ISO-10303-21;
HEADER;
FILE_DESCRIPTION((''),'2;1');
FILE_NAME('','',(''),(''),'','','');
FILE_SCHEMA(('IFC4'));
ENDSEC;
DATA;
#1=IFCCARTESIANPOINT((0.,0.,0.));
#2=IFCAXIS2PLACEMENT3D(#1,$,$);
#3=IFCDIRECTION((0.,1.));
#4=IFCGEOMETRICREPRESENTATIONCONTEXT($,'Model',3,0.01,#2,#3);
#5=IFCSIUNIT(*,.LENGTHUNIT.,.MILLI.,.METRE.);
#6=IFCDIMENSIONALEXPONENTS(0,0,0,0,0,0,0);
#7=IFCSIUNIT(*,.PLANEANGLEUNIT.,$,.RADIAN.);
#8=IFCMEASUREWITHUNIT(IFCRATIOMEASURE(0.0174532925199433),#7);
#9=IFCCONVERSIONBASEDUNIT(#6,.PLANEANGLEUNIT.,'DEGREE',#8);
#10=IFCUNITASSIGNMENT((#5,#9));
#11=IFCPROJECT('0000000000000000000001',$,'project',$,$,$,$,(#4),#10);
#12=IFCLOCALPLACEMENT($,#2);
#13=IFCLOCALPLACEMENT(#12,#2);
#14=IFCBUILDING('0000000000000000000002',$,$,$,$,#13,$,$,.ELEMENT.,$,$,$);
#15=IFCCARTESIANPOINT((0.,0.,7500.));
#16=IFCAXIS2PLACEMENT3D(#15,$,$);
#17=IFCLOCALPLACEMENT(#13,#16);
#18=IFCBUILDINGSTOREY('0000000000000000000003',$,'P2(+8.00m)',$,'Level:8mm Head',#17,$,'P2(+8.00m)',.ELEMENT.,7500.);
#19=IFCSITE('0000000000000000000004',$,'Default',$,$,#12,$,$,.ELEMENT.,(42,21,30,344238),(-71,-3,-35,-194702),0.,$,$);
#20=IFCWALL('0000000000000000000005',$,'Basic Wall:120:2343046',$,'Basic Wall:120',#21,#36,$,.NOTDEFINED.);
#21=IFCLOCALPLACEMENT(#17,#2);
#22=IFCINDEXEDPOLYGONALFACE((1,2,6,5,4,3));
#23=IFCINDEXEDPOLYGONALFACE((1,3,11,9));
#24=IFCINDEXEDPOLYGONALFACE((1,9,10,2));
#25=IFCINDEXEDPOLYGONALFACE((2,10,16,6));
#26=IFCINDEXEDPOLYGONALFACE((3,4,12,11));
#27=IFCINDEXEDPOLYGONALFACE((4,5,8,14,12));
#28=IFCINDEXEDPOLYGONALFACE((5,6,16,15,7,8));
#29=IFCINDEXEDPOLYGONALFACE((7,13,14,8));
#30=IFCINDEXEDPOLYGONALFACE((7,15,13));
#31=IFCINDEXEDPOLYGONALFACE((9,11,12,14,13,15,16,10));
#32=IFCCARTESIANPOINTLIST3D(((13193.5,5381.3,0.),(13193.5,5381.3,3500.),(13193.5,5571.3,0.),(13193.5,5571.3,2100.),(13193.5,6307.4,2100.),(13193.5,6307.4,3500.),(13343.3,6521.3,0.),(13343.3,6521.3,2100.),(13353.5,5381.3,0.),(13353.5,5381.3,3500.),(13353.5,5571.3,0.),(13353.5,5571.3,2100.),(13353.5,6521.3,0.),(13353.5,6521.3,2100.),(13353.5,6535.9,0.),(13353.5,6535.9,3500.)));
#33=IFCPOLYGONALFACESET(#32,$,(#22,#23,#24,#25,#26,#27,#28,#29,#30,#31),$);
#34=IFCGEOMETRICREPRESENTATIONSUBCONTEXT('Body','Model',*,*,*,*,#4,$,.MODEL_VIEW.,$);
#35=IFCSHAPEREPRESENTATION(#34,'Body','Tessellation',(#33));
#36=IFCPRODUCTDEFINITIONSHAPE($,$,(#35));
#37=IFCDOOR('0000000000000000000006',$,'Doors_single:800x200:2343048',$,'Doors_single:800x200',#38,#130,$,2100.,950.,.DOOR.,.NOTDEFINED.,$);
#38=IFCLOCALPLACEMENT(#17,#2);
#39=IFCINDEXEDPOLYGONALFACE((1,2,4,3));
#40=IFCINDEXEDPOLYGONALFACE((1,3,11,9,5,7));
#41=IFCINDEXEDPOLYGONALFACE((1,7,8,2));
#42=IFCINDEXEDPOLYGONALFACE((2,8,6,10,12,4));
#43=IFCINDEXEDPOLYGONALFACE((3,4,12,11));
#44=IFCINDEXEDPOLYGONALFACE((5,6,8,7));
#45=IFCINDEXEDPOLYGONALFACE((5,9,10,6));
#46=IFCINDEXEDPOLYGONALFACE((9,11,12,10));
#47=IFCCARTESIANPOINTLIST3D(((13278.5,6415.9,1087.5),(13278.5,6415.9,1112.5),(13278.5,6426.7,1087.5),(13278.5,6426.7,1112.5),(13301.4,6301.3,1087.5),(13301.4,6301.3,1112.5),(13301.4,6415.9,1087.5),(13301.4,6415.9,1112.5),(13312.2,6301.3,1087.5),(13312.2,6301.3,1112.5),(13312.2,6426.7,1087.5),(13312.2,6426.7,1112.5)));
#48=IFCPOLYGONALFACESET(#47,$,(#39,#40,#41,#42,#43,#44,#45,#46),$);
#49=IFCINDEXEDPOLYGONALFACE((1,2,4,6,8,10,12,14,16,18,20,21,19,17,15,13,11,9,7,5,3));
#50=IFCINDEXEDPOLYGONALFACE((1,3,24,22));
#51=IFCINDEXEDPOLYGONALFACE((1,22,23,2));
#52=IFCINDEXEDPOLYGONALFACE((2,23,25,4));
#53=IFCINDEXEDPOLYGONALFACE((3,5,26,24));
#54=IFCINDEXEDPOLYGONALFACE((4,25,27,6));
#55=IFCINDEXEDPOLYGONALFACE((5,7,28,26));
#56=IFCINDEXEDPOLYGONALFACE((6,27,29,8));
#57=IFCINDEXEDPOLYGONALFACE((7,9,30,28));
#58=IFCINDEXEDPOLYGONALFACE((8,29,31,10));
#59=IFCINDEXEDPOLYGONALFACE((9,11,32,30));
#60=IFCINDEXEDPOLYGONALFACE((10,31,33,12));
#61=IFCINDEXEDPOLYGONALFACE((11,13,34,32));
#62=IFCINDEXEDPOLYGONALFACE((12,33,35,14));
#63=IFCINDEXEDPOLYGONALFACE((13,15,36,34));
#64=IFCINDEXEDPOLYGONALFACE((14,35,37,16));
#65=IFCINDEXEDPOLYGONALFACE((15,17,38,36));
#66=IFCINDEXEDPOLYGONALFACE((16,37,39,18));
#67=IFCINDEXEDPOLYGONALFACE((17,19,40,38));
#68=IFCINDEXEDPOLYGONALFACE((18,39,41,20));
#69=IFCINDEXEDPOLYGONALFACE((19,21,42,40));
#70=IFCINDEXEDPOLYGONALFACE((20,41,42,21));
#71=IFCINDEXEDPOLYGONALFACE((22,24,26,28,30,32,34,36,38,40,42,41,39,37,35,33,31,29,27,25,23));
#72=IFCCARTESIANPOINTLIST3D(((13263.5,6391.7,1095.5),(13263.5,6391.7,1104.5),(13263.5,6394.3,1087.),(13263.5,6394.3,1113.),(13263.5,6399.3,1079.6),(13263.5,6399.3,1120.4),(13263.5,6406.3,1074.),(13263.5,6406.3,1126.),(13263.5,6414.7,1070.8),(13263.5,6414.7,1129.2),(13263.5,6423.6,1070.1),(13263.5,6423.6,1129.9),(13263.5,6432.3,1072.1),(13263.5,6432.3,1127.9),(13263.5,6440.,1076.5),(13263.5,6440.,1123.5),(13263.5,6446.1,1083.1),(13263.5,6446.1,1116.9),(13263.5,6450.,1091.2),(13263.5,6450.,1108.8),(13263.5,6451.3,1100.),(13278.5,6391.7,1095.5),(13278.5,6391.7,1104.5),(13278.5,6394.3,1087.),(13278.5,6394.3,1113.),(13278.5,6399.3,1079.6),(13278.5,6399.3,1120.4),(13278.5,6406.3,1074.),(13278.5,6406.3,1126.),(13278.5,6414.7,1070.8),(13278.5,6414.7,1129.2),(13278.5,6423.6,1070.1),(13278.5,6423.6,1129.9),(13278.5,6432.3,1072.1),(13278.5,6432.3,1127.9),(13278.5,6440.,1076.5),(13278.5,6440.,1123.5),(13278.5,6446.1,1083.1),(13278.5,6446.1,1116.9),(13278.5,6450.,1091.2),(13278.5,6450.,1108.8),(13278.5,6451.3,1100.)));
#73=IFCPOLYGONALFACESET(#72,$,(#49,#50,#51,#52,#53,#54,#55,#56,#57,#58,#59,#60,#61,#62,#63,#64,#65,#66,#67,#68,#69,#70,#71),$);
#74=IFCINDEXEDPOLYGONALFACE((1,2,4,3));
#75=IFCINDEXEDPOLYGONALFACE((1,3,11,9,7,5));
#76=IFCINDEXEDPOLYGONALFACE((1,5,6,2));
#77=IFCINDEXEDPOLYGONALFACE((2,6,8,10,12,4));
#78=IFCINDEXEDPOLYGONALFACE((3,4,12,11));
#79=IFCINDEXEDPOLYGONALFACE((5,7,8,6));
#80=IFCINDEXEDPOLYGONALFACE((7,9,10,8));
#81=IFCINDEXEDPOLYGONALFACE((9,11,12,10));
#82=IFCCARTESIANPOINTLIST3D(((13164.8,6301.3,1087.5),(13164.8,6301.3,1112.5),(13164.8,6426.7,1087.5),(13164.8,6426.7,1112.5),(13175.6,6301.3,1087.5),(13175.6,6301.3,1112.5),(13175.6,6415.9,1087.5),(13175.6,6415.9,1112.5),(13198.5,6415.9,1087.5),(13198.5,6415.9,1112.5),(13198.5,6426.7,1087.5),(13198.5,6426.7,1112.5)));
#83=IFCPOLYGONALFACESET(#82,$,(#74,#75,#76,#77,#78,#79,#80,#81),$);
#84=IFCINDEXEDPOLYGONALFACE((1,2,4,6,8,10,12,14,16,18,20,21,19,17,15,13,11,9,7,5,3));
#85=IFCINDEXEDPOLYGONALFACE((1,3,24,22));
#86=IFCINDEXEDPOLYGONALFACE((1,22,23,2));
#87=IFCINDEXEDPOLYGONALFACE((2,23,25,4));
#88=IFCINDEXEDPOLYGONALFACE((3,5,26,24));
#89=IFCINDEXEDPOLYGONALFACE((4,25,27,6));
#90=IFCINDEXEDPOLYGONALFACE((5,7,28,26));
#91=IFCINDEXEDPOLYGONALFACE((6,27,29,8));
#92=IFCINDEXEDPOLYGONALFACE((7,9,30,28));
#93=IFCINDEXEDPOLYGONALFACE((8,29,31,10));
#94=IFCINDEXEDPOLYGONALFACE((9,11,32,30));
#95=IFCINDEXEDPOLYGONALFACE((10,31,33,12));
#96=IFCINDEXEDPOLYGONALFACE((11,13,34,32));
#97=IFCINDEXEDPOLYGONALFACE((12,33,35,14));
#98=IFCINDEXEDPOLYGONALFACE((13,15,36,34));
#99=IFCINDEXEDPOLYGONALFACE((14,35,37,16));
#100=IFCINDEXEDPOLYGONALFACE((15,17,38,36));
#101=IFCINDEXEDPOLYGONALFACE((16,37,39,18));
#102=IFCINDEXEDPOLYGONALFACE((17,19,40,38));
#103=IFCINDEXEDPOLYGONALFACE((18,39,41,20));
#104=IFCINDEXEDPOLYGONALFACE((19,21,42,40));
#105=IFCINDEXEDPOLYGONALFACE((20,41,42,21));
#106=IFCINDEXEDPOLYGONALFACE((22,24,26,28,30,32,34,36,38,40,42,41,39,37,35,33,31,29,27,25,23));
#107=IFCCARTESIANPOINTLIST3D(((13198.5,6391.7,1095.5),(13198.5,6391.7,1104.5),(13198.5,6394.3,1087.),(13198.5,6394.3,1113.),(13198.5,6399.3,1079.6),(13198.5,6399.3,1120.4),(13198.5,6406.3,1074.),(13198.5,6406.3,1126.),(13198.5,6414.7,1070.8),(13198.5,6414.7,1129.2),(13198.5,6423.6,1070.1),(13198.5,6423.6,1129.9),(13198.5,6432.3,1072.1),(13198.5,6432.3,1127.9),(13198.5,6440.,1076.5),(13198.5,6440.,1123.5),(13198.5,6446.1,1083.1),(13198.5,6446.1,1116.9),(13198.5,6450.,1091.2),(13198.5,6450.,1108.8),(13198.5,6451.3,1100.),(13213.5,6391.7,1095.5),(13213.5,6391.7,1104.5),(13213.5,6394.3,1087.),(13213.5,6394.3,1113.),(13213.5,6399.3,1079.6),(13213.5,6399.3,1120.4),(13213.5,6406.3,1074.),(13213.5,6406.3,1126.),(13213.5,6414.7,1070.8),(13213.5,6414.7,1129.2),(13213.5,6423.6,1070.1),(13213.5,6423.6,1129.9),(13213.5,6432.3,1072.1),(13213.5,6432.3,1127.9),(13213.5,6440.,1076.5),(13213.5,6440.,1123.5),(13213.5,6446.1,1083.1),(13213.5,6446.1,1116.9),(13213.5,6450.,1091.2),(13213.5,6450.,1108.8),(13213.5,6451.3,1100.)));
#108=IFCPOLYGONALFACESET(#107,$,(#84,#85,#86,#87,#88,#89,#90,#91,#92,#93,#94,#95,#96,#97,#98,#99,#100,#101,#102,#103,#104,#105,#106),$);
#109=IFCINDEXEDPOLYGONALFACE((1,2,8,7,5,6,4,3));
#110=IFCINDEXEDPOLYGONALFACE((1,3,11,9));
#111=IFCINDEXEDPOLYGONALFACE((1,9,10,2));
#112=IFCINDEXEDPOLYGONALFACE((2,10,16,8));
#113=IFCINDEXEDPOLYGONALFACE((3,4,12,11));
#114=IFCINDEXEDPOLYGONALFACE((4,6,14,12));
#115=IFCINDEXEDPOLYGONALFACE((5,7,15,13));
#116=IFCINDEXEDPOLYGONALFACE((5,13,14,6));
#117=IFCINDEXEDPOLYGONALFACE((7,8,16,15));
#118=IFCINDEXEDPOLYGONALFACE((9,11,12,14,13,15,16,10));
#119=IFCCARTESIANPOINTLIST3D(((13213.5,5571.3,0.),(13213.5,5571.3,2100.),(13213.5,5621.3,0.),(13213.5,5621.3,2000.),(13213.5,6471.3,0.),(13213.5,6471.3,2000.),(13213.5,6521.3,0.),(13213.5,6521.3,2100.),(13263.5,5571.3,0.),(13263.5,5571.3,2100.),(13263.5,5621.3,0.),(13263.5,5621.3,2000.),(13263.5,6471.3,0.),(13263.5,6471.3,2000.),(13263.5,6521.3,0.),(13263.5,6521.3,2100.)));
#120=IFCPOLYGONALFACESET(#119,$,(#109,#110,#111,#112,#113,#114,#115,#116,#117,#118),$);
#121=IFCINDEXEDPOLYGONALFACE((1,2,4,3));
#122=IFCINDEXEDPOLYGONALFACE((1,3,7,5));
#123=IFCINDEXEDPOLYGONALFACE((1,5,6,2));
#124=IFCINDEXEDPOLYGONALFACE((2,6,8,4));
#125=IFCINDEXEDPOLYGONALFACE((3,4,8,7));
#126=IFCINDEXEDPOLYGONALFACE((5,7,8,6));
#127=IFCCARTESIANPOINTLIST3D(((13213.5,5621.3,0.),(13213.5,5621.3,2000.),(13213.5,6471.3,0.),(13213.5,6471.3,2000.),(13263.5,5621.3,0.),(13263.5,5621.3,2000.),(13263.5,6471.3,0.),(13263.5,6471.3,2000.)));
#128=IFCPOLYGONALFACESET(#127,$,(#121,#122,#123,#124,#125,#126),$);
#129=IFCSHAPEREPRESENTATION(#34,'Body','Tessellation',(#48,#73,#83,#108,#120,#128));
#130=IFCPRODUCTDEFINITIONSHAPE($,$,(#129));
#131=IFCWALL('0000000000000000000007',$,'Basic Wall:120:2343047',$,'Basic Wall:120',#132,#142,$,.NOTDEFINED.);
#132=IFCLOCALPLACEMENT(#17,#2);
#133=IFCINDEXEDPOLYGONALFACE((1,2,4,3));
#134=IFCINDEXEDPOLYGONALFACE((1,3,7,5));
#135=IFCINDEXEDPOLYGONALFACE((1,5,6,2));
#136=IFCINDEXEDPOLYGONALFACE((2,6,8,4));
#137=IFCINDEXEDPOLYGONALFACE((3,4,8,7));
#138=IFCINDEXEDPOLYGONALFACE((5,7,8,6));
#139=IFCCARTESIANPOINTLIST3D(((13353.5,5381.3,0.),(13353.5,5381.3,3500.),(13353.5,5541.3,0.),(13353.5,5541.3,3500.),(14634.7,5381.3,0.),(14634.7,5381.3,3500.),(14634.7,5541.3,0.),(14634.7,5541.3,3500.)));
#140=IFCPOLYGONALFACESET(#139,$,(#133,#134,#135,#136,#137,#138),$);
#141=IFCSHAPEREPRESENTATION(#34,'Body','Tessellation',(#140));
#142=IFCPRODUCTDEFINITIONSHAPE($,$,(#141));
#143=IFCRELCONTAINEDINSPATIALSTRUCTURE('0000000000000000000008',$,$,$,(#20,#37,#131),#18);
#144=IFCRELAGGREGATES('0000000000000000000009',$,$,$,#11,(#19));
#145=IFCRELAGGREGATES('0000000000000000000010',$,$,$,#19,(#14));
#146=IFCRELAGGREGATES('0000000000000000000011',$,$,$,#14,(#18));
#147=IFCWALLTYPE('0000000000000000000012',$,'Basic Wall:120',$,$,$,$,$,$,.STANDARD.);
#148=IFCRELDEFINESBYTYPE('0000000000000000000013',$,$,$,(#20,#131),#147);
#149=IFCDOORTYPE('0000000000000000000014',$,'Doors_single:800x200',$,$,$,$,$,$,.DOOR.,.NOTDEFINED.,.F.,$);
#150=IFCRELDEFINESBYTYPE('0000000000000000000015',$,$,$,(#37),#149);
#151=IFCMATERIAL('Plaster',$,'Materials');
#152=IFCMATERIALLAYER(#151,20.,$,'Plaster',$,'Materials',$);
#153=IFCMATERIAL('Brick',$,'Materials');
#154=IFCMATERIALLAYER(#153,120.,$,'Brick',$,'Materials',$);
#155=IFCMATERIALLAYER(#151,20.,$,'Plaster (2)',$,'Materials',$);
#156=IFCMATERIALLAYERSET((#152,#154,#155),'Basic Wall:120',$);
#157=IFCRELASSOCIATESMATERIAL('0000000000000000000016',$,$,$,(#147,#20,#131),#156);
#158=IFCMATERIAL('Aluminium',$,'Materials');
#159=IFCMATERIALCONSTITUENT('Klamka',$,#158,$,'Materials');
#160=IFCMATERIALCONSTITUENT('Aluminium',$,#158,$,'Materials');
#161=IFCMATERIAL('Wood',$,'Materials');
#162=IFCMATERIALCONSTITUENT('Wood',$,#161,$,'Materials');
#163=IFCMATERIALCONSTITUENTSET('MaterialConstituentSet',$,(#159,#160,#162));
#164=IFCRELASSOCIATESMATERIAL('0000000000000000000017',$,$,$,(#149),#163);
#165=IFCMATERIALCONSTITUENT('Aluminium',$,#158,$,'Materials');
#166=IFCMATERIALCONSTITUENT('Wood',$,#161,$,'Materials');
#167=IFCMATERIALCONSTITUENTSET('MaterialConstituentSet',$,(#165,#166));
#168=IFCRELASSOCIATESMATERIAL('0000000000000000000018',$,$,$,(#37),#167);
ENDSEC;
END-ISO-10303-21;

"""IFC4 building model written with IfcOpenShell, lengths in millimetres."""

from ifc_helpers import new_model, entity, si_unit, converted_unit, direction, frame, frame_2d, origin, origin_2d_with_axis, place, context, subcontext, project, spatial, polyline, rectangle, circle, outline, extrude, source, transform, mapped, material, layer, layer_set, layer_usage, constituent, constituent_set, type_object, type_shapes, element, fill, save


model = new_model("IFC4")

# Units and contexts
model_context = context("Model", 3, precision=0.01, world=origin(), true_north=direction((0.0, 1.0)))
body_context = subcontext(model_context, "Body", "Model", "MODEL_VIEW")
ifc_project = project(units=[si_unit("LENGTHUNIT", "METRE", prefix="MILLI"), converted_unit("PLANEANGLEUNIT", "DEGREE", entity("IfcRatioMeasure", 0.0174532925199433), si_unit("PLANEANGLEUNIT", "RADIAN"), dimensions=[0, 0, 0, 0, 0, 0, 0])], contexts=[model_context])

# Site, building, storey
site_placement = place(None, origin())
site = spatial("IfcSite", under=ifc_project, at=site_placement, Name="Default", CompositionType="ELEMENT", RefLatitude=(42, 21, 30, 344238), RefLongitude=(-71, -3, -35, -194702), RefElevation=0.0)
building_placement = place(site_placement, origin())
building = spatial("IfcBuilding", under=site, at=building_placement, CompositionType="ELEMENT")
storey_placement = place(building_placement, frame((0.0, 0.0, 7500.0)))
storey = spatial("IfcBuildingStorey", under=building, at=storey_placement, Name="P2(+8.00m)", ObjectType="Level:8mm Head", LongName="P2(+8.00m)", CompositionType="ELEMENT", Elevation=7500.0)

# Shared definitions
ifc_material_1 = material(Name="Brick", Category="Materials")
ifc_material_2 = material(Name="Plaster", Category="Materials")

# Shared definitions
ifc_material_3 = material(Name="Aluminium", Category="Materials")
ifc_material_4 = material(Name="Wood", Category="Materials")

# Shared definitions
ifc_layer_1 = layer(ifc_material_2, 20.0, Name="Plaster", Category="Materials")
ifc_layer_2 = layer(ifc_material_1, 120.0, Name="Brick", Category="Materials")
ifc_layer_3 = layer(ifc_material_2, 20.0, Name="Plaster (2)", Category="Materials")
ifc_layer_set_1 = layer_set([ifc_layer_1, ifc_layer_2, ifc_layer_3], Name="Basic Wall:120")
wall_type_1 = type_object("IfcWallType", Name="Basic Wall:120", PredefinedType="STANDARD", material=ifc_layer_set_1)

# Wall, opening, door
ifc_layer_usage_1 = layer_usage(ifc_layer_set_1, "AXIS2", "POSITIVE", -80.0)
wall_1_placement = place(storey_placement, frame((13273.5, 6535.9, 0.0), z_axis=(0.0, 0.0, 1.0), x_axis=(0.0, -1.0, 0.0)))
wall_1 = element("IfcWall", 1, at=wall_1_placement, inside=storey, type_object=wall_type_1, material=ifc_layer_usage_1, Name="Basic Wall:120:2343046", ObjectType="Basic Wall:120", PredefinedType="NOTDEFINED", context=body_context, shape_type="SweptSolid", body=[
    extrude(outline(polyline([(228.5, -80.0), (1154.6, -80.0), (1154.6, 80.0), (994.6, 80.0), (0.0, 80.0), (228.5, -80.0)])), origin(), (0.0, 0.0, 1.0), 3500.0),
])
opening_1_placement = place(wall_1_placement, frame((964.6, 80.0, 0.0)))
opening_1 = element("IfcOpeningElement", 2, at=opening_1_placement, cuts=wall_1, PredefinedType="OPENING", context=body_context, shape_type="SweptSolid", body=[
    extrude(rectangle(XDim=2100.0, YDim=950.0, at=frame_2d((1050.0, 475.0), x_axis=(1.0, 0.0))), frame((0.0, 0.0, 0.0), z_axis=(0.0, -1.0, 0.0), x_axis=(0.0, 0.0, 1.0)), (0.0, 0.0, 1.0), 160.0),
])
ifc_constituent_1 = constituent(ifc_material_3, Name="Aluminium", Category="Materials")
ifc_constituent_2 = constituent(ifc_material_4, Name="Wood", Category="Materials")
ifc_constituent_set_1 = constituent_set(constituents=[ifc_constituent_1, ifc_constituent_2], Name="MaterialConstituentSet")
ifc_constituent_3 = constituent(ifc_material_3, Name="Klamka", Category="Materials")
ifc_constituent_4 = constituent(ifc_material_3, Name="Aluminium", Category="Materials")
ifc_constituent_5 = constituent(ifc_material_4, Name="Wood", Category="Materials")
ifc_constituent_set_2 = constituent_set(constituents=[ifc_constituent_3, ifc_constituent_4, ifc_constituent_5], Name="MaterialConstituentSet")
door_type_1 = type_object("IfcDoorType", Name="Doors_single:800x200", OperationType="NOTDEFINED", ParameterTakesPrecedence=False, PredefinedType="DOOR", material=ifc_constituent_set_2)
shared_shape_1 = source(origin(), body_context, "Body", "SweptSolid", [
    extrude(outline(polyline([(-45.4, -18.9), (-34.6, -18.9), (-34.6, 4.0), (80.0, 4.0), (80.0, 14.8), (-45.4, 14.8), (-45.4, -18.9)])), frame((810.0, 56.1, 1087.5), z_axis=(0.0, 0.0, 1.0), x_axis=(-1.0, 0.0, 0.0)), (0.0, 0.0, 1.0), 25.0),
    extrude(circle(Radius=30.0, at=origin_2d_with_axis()), frame((850.0, 75.0, 1100.0), z_axis=(0.0, 1.0, 0.0), x_axis=(1.0, 0.0, 0.0)), (0.0, 0.0, 1.0), 15.0),
    extrude(outline(polyline([(-18.9, -45.4), (14.8, -45.4), (14.8, 80.0), (4.0, 80.0), (4.0, -34.6), (-18.9, -34.6), (-18.9, -45.4)])), frame((810.0, 173.9, 1087.5), z_axis=(0.0, 0.0, 1.0), x_axis=(0.0, 1.0, 0.0)), (0.0, 0.0, 1.0), 25.0),
    extrude(circle(Radius=30.0, at=origin_2d_with_axis()), frame((850.0, 140.0, 1100.0), z_axis=(0.0, 1.0, 0.0), x_axis=(1.0, 0.0, 0.0)), (0.0, 0.0, 1.0), 15.0),
    extrude(outline(polyline([(-475.0, -1025.0), (-425.0, -1025.0), (-425.0, 975.0), (425.0, 975.0), (425.0, -1025.0), (475.0, -1025.0), (475.0, 1075.0), (-475.0, 1075.0), (-475.0, -1025.0)])), frame((475.0, 90.0, 1025.0), z_axis=(0.0, 1.0, 0.0), x_axis=(-1.0, 0.0, 0.0)), (0.0, 0.0, 1.0), 50.0),
    extrude(rectangle(XDim=850.0, YDim=50.0, at=origin_2d_with_axis()), frame((475.0, 115.0, 0.0), z_axis=(0.0, 0.0, 1.0), x_axis=(-1.0, 0.0, 0.0)), (0.0, 0.0, 1.0), 2000.0),
])
type_shapes(door_type_1, [shared_shape_1])
door_1_placement = place(opening_1_placement, frame((0.0, 0.0, 0.0), z_axis=(0.0, 0.0, 1.0), x_axis=(-1.0, 0.0, 0.0)))
door_1 = element("IfcDoor", 3, at=door_1_placement, inside=storey, type_object=door_type_1, material=ifc_constituent_set_1, Name="Doors_single:800x200:2343048", ObjectType="Doors_single:800x200", OperationType="NOTDEFINED", OverallHeight=2100.0, OverallWidth=950.0, PredefinedType="DOOR", context=body_context, shape_type="MappedRepresentation", body=[
    mapped(shared_shape_1, transform((0.0, 0.0, 0.0), scale=1.0)),
])
fill(opening_1, door_1)

# Wall
ifc_layer_usage_2 = layer_usage(ifc_layer_set_1, "AXIS2", "NEGATIVE", 80.0)
wall_2_placement = place(storey_placement, frame((13353.5, 5461.3, 0.0)))
element("IfcWall", 4, at=wall_2_placement, inside=storey, type_object=wall_type_1, material=ifc_layer_usage_2, Name="Basic Wall:120:2343047", ObjectType="Basic Wall:120", PredefinedType="NOTDEFINED", context=body_context, shape_type="SweptSolid", body=[
    extrude(rectangle(XDim=1281.2, YDim=160.0, at=frame_2d((640.6, 0.0), x_axis=(-1.0, 0.0))), origin(), (0.0, 0.0, 1.0), 3500.0),
])

save(model, "model.ifc")
